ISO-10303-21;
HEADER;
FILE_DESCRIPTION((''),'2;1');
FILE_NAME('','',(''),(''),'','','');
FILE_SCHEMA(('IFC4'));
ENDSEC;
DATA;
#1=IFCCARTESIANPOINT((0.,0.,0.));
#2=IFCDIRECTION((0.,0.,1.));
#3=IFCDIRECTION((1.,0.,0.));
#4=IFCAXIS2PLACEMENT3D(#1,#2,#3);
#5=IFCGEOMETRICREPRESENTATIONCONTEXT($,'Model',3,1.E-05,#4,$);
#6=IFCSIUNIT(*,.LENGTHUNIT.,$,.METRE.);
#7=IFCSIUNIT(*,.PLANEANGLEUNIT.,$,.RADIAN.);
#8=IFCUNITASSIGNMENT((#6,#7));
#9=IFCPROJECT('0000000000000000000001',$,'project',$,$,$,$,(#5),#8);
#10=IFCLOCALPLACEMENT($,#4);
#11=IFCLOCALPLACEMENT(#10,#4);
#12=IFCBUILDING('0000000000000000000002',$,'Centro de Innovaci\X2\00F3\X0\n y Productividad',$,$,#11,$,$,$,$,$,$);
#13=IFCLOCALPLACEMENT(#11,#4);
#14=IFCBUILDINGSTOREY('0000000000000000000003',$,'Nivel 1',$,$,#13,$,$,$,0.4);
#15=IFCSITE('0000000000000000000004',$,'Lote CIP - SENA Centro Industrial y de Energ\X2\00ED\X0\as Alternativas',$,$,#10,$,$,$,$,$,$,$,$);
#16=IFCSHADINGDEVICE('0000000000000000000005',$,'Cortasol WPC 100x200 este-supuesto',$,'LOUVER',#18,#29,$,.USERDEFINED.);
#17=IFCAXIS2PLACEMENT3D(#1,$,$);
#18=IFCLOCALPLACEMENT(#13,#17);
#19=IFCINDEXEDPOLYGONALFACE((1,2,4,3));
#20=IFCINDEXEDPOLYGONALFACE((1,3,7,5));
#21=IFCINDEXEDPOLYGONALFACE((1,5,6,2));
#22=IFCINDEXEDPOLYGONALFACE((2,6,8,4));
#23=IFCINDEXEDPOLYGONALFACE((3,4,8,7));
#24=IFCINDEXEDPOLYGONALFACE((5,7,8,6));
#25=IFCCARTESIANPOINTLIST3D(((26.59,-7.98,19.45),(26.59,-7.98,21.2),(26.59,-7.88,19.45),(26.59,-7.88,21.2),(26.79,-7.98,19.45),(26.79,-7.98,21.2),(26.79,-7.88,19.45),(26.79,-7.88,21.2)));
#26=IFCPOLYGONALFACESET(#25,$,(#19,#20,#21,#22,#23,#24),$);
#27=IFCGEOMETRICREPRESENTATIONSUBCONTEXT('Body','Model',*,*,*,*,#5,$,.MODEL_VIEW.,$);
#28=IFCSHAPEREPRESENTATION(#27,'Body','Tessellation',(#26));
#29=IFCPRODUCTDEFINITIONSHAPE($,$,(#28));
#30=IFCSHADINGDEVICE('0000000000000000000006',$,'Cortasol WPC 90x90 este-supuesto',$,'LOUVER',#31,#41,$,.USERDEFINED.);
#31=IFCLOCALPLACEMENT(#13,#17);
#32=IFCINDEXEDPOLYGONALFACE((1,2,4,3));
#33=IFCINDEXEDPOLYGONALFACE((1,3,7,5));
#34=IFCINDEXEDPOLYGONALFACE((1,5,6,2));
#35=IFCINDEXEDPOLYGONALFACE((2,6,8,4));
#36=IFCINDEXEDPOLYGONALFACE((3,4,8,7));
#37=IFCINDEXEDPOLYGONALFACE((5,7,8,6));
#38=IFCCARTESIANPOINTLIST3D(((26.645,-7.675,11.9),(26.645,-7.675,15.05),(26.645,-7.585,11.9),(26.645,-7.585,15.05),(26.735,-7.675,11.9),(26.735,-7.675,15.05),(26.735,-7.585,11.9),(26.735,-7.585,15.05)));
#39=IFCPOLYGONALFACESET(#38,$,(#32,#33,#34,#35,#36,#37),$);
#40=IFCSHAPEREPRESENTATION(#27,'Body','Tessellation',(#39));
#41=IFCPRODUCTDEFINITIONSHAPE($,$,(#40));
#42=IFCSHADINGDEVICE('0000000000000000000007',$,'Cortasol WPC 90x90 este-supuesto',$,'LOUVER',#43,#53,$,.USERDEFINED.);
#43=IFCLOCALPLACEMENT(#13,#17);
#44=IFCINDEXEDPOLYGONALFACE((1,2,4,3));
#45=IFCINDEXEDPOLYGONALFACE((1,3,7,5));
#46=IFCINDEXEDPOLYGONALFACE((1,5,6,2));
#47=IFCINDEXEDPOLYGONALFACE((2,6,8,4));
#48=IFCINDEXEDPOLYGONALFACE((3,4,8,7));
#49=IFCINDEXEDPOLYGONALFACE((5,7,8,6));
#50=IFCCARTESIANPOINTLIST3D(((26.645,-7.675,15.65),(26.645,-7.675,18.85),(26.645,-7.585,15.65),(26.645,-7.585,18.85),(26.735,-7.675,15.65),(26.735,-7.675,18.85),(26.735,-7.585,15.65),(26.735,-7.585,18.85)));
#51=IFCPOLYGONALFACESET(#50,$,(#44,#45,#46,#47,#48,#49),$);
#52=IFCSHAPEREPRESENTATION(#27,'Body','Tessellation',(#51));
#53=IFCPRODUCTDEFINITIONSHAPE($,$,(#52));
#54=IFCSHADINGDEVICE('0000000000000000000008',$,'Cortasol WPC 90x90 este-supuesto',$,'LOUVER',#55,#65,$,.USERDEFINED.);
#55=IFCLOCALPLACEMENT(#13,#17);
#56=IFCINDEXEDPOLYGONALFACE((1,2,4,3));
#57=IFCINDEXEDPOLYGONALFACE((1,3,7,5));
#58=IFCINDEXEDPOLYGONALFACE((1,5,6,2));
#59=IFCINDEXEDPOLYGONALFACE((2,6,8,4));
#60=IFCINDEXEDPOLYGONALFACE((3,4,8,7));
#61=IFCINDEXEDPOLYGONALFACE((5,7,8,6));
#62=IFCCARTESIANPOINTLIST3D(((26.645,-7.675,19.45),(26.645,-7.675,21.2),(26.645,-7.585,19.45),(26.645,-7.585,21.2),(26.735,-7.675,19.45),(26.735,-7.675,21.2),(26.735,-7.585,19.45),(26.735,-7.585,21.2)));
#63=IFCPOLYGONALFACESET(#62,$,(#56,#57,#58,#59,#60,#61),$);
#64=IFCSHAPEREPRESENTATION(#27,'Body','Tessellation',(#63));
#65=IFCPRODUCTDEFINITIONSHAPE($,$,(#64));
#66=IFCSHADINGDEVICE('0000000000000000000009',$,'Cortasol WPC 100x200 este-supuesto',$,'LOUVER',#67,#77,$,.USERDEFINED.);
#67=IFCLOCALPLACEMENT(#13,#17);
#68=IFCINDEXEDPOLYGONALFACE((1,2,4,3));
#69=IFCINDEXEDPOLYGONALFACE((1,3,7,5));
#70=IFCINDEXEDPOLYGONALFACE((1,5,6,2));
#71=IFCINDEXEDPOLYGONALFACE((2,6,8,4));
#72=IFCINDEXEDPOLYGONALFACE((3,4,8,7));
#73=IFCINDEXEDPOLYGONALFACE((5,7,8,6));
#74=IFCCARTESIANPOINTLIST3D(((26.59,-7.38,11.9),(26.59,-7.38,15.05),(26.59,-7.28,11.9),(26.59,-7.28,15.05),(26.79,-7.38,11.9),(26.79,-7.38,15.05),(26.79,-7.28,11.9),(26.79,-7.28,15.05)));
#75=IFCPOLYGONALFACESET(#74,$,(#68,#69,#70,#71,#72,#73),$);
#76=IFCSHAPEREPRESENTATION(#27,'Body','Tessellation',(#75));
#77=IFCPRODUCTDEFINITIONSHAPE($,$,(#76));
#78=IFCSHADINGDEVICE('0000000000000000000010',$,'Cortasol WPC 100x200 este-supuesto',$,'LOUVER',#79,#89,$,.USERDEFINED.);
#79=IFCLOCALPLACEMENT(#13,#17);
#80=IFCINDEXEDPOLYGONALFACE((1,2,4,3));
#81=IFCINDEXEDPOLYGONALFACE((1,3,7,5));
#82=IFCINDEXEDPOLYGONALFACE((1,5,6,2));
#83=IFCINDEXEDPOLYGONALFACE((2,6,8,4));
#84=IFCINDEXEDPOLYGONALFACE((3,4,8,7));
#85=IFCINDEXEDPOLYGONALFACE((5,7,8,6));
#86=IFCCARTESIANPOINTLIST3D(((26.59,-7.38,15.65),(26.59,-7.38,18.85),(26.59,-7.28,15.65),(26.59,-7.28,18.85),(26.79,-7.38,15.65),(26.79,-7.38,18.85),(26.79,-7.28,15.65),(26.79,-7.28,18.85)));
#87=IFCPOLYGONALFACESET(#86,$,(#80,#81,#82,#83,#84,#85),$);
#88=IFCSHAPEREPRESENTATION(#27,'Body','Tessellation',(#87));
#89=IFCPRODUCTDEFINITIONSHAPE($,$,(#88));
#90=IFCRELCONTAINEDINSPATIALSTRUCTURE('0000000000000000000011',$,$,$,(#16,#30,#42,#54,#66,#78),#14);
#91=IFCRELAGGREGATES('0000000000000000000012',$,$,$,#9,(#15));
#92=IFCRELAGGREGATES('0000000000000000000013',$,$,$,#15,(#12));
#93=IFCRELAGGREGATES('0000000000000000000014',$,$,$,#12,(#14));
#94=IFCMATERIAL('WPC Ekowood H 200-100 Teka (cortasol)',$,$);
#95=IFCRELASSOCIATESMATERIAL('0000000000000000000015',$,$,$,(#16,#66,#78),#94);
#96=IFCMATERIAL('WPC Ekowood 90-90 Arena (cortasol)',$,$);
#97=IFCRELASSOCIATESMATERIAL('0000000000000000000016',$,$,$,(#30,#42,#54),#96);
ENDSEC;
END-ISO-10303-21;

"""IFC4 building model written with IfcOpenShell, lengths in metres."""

from ifc_helpers import new_model, si_unit, frame, origin_with_axes, place, context, subcontext, project, spatial, polyline, outline, extrude, material, element, save


model = new_model("IFC4")

# Units and contexts
model_context = context("Model", 3, precision=1e-05, world=origin_with_axes())
body_context = subcontext(model_context, "Body", "Model", "MODEL_VIEW")
ifc_project = project(units=[si_unit("LENGTHUNIT", "METRE"), si_unit("PLANEANGLEUNIT", "RADIAN")], contexts=[model_context])

# Site, building, storey
site_placement = place(None, origin_with_axes())
site = spatial("IfcSite", under=ifc_project, at=site_placement, Name="Lote CIP - SENA Centro Industrial y de Energías Alternativas")
building_placement = place(site_placement, origin_with_axes())
building = spatial("IfcBuilding", under=site, at=building_placement, Name="Centro de Innovación y Productividad")
storey_placement = place(building_placement, origin_with_axes())
storey = spatial("IfcBuildingStorey", under=building, at=storey_placement, Name="Nivel 1", Elevation=0.4)

# Shading devices
ifc_material_1 = material(Name="WPC Ekowood 90-90 Arena (cortasol)")
ifc_material_2 = material(Name="WPC Ekowood H 200-100 Teka (cortasol)")
shading_device_1_placement = place(storey_placement, origin_with_axes())
element("IfcShadingDevice", 1, at=shading_device_1_placement, inside=storey, material=ifc_material_2, Name="Cortasol WPC 100x200 este-supuesto", ObjectType="LOUVER", PredefinedType="USERDEFINED", context=body_context, shape_type="SweptSolid", body=[
    extrude(outline(polyline([(26.79, -7.98), (26.59, -7.98), (26.59, -7.88), (26.79, -7.88), (26.79, -7.98)])), frame((0.0, 0.0, 19.45)), (0.0, 0.0, 1.0), 1.75),
])
shading_device_2_placement = place(storey_placement, origin_with_axes())
element("IfcShadingDevice", 2, at=shading_device_2_placement, inside=storey, material=ifc_material_1, Name="Cortasol WPC 90x90 este-supuesto", ObjectType="LOUVER", PredefinedType="USERDEFINED", context=body_context, shape_type="SweptSolid", body=[
    extrude(outline(polyline([(26.735, -7.675), (26.645, -7.675), (26.645, -7.585), (26.735, -7.585), (26.735, -7.675)])), frame((0.0, 0.0, 11.9)), (0.0, 0.0, 1.0), 3.15),
])
shading_device_3_placement = place(storey_placement, origin_with_axes())
element("IfcShadingDevice", 3, at=shading_device_3_placement, inside=storey, material=ifc_material_1, Name="Cortasol WPC 90x90 este-supuesto", ObjectType="LOUVER", PredefinedType="USERDEFINED", context=body_context, shape_type="SweptSolid", body=[
    extrude(outline(polyline([(26.735, -7.675), (26.645, -7.675), (26.645, -7.585), (26.735, -7.585), (26.735, -7.675)])), frame((0.0, 0.0, 15.65)), (0.0, 0.0, 1.0), 3.2),
])
shading_device_4_placement = place(storey_placement, origin_with_axes())
element("IfcShadingDevice", 4, at=shading_device_4_placement, inside=storey, material=ifc_material_1, Name="Cortasol WPC 90x90 este-supuesto", ObjectType="LOUVER", PredefinedType="USERDEFINED", context=body_context, shape_type="SweptSolid", body=[
    extrude(outline(polyline([(26.735, -7.675), (26.645, -7.675), (26.645, -7.585), (26.735, -7.585), (26.735, -7.675)])), frame((0.0, 0.0, 19.45)), (0.0, 0.0, 1.0), 1.75),
])
shading_device_5_placement = place(storey_placement, origin_with_axes())
element("IfcShadingDevice", 5, at=shading_device_5_placement, inside=storey, material=ifc_material_2, Name="Cortasol WPC 100x200 este-supuesto", ObjectType="LOUVER", PredefinedType="USERDEFINED", context=body_context, shape_type="SweptSolid", body=[
    extrude(outline(polyline([(26.79, -7.38), (26.59, -7.38), (26.59, -7.28), (26.79, -7.28), (26.79, -7.38)])), frame((0.0, 0.0, 11.9)), (0.0, 0.0, 1.0), 3.15),
])
shading_device_6_placement = place(storey_placement, origin_with_axes())
element("IfcShadingDevice", 6, at=shading_device_6_placement, inside=storey, material=ifc_material_2, Name="Cortasol WPC 100x200 este-supuesto", ObjectType="LOUVER", PredefinedType="USERDEFINED", context=body_context, shape_type="SweptSolid", body=[
    extrude(outline(polyline([(26.79, -7.38), (26.59, -7.38), (26.59, -7.28), (26.79, -7.28), (26.79, -7.38)])), frame((0.0, 0.0, 15.65)), (0.0, 0.0, 1.0), 3.2),
])

save(model, "model.ifc")
